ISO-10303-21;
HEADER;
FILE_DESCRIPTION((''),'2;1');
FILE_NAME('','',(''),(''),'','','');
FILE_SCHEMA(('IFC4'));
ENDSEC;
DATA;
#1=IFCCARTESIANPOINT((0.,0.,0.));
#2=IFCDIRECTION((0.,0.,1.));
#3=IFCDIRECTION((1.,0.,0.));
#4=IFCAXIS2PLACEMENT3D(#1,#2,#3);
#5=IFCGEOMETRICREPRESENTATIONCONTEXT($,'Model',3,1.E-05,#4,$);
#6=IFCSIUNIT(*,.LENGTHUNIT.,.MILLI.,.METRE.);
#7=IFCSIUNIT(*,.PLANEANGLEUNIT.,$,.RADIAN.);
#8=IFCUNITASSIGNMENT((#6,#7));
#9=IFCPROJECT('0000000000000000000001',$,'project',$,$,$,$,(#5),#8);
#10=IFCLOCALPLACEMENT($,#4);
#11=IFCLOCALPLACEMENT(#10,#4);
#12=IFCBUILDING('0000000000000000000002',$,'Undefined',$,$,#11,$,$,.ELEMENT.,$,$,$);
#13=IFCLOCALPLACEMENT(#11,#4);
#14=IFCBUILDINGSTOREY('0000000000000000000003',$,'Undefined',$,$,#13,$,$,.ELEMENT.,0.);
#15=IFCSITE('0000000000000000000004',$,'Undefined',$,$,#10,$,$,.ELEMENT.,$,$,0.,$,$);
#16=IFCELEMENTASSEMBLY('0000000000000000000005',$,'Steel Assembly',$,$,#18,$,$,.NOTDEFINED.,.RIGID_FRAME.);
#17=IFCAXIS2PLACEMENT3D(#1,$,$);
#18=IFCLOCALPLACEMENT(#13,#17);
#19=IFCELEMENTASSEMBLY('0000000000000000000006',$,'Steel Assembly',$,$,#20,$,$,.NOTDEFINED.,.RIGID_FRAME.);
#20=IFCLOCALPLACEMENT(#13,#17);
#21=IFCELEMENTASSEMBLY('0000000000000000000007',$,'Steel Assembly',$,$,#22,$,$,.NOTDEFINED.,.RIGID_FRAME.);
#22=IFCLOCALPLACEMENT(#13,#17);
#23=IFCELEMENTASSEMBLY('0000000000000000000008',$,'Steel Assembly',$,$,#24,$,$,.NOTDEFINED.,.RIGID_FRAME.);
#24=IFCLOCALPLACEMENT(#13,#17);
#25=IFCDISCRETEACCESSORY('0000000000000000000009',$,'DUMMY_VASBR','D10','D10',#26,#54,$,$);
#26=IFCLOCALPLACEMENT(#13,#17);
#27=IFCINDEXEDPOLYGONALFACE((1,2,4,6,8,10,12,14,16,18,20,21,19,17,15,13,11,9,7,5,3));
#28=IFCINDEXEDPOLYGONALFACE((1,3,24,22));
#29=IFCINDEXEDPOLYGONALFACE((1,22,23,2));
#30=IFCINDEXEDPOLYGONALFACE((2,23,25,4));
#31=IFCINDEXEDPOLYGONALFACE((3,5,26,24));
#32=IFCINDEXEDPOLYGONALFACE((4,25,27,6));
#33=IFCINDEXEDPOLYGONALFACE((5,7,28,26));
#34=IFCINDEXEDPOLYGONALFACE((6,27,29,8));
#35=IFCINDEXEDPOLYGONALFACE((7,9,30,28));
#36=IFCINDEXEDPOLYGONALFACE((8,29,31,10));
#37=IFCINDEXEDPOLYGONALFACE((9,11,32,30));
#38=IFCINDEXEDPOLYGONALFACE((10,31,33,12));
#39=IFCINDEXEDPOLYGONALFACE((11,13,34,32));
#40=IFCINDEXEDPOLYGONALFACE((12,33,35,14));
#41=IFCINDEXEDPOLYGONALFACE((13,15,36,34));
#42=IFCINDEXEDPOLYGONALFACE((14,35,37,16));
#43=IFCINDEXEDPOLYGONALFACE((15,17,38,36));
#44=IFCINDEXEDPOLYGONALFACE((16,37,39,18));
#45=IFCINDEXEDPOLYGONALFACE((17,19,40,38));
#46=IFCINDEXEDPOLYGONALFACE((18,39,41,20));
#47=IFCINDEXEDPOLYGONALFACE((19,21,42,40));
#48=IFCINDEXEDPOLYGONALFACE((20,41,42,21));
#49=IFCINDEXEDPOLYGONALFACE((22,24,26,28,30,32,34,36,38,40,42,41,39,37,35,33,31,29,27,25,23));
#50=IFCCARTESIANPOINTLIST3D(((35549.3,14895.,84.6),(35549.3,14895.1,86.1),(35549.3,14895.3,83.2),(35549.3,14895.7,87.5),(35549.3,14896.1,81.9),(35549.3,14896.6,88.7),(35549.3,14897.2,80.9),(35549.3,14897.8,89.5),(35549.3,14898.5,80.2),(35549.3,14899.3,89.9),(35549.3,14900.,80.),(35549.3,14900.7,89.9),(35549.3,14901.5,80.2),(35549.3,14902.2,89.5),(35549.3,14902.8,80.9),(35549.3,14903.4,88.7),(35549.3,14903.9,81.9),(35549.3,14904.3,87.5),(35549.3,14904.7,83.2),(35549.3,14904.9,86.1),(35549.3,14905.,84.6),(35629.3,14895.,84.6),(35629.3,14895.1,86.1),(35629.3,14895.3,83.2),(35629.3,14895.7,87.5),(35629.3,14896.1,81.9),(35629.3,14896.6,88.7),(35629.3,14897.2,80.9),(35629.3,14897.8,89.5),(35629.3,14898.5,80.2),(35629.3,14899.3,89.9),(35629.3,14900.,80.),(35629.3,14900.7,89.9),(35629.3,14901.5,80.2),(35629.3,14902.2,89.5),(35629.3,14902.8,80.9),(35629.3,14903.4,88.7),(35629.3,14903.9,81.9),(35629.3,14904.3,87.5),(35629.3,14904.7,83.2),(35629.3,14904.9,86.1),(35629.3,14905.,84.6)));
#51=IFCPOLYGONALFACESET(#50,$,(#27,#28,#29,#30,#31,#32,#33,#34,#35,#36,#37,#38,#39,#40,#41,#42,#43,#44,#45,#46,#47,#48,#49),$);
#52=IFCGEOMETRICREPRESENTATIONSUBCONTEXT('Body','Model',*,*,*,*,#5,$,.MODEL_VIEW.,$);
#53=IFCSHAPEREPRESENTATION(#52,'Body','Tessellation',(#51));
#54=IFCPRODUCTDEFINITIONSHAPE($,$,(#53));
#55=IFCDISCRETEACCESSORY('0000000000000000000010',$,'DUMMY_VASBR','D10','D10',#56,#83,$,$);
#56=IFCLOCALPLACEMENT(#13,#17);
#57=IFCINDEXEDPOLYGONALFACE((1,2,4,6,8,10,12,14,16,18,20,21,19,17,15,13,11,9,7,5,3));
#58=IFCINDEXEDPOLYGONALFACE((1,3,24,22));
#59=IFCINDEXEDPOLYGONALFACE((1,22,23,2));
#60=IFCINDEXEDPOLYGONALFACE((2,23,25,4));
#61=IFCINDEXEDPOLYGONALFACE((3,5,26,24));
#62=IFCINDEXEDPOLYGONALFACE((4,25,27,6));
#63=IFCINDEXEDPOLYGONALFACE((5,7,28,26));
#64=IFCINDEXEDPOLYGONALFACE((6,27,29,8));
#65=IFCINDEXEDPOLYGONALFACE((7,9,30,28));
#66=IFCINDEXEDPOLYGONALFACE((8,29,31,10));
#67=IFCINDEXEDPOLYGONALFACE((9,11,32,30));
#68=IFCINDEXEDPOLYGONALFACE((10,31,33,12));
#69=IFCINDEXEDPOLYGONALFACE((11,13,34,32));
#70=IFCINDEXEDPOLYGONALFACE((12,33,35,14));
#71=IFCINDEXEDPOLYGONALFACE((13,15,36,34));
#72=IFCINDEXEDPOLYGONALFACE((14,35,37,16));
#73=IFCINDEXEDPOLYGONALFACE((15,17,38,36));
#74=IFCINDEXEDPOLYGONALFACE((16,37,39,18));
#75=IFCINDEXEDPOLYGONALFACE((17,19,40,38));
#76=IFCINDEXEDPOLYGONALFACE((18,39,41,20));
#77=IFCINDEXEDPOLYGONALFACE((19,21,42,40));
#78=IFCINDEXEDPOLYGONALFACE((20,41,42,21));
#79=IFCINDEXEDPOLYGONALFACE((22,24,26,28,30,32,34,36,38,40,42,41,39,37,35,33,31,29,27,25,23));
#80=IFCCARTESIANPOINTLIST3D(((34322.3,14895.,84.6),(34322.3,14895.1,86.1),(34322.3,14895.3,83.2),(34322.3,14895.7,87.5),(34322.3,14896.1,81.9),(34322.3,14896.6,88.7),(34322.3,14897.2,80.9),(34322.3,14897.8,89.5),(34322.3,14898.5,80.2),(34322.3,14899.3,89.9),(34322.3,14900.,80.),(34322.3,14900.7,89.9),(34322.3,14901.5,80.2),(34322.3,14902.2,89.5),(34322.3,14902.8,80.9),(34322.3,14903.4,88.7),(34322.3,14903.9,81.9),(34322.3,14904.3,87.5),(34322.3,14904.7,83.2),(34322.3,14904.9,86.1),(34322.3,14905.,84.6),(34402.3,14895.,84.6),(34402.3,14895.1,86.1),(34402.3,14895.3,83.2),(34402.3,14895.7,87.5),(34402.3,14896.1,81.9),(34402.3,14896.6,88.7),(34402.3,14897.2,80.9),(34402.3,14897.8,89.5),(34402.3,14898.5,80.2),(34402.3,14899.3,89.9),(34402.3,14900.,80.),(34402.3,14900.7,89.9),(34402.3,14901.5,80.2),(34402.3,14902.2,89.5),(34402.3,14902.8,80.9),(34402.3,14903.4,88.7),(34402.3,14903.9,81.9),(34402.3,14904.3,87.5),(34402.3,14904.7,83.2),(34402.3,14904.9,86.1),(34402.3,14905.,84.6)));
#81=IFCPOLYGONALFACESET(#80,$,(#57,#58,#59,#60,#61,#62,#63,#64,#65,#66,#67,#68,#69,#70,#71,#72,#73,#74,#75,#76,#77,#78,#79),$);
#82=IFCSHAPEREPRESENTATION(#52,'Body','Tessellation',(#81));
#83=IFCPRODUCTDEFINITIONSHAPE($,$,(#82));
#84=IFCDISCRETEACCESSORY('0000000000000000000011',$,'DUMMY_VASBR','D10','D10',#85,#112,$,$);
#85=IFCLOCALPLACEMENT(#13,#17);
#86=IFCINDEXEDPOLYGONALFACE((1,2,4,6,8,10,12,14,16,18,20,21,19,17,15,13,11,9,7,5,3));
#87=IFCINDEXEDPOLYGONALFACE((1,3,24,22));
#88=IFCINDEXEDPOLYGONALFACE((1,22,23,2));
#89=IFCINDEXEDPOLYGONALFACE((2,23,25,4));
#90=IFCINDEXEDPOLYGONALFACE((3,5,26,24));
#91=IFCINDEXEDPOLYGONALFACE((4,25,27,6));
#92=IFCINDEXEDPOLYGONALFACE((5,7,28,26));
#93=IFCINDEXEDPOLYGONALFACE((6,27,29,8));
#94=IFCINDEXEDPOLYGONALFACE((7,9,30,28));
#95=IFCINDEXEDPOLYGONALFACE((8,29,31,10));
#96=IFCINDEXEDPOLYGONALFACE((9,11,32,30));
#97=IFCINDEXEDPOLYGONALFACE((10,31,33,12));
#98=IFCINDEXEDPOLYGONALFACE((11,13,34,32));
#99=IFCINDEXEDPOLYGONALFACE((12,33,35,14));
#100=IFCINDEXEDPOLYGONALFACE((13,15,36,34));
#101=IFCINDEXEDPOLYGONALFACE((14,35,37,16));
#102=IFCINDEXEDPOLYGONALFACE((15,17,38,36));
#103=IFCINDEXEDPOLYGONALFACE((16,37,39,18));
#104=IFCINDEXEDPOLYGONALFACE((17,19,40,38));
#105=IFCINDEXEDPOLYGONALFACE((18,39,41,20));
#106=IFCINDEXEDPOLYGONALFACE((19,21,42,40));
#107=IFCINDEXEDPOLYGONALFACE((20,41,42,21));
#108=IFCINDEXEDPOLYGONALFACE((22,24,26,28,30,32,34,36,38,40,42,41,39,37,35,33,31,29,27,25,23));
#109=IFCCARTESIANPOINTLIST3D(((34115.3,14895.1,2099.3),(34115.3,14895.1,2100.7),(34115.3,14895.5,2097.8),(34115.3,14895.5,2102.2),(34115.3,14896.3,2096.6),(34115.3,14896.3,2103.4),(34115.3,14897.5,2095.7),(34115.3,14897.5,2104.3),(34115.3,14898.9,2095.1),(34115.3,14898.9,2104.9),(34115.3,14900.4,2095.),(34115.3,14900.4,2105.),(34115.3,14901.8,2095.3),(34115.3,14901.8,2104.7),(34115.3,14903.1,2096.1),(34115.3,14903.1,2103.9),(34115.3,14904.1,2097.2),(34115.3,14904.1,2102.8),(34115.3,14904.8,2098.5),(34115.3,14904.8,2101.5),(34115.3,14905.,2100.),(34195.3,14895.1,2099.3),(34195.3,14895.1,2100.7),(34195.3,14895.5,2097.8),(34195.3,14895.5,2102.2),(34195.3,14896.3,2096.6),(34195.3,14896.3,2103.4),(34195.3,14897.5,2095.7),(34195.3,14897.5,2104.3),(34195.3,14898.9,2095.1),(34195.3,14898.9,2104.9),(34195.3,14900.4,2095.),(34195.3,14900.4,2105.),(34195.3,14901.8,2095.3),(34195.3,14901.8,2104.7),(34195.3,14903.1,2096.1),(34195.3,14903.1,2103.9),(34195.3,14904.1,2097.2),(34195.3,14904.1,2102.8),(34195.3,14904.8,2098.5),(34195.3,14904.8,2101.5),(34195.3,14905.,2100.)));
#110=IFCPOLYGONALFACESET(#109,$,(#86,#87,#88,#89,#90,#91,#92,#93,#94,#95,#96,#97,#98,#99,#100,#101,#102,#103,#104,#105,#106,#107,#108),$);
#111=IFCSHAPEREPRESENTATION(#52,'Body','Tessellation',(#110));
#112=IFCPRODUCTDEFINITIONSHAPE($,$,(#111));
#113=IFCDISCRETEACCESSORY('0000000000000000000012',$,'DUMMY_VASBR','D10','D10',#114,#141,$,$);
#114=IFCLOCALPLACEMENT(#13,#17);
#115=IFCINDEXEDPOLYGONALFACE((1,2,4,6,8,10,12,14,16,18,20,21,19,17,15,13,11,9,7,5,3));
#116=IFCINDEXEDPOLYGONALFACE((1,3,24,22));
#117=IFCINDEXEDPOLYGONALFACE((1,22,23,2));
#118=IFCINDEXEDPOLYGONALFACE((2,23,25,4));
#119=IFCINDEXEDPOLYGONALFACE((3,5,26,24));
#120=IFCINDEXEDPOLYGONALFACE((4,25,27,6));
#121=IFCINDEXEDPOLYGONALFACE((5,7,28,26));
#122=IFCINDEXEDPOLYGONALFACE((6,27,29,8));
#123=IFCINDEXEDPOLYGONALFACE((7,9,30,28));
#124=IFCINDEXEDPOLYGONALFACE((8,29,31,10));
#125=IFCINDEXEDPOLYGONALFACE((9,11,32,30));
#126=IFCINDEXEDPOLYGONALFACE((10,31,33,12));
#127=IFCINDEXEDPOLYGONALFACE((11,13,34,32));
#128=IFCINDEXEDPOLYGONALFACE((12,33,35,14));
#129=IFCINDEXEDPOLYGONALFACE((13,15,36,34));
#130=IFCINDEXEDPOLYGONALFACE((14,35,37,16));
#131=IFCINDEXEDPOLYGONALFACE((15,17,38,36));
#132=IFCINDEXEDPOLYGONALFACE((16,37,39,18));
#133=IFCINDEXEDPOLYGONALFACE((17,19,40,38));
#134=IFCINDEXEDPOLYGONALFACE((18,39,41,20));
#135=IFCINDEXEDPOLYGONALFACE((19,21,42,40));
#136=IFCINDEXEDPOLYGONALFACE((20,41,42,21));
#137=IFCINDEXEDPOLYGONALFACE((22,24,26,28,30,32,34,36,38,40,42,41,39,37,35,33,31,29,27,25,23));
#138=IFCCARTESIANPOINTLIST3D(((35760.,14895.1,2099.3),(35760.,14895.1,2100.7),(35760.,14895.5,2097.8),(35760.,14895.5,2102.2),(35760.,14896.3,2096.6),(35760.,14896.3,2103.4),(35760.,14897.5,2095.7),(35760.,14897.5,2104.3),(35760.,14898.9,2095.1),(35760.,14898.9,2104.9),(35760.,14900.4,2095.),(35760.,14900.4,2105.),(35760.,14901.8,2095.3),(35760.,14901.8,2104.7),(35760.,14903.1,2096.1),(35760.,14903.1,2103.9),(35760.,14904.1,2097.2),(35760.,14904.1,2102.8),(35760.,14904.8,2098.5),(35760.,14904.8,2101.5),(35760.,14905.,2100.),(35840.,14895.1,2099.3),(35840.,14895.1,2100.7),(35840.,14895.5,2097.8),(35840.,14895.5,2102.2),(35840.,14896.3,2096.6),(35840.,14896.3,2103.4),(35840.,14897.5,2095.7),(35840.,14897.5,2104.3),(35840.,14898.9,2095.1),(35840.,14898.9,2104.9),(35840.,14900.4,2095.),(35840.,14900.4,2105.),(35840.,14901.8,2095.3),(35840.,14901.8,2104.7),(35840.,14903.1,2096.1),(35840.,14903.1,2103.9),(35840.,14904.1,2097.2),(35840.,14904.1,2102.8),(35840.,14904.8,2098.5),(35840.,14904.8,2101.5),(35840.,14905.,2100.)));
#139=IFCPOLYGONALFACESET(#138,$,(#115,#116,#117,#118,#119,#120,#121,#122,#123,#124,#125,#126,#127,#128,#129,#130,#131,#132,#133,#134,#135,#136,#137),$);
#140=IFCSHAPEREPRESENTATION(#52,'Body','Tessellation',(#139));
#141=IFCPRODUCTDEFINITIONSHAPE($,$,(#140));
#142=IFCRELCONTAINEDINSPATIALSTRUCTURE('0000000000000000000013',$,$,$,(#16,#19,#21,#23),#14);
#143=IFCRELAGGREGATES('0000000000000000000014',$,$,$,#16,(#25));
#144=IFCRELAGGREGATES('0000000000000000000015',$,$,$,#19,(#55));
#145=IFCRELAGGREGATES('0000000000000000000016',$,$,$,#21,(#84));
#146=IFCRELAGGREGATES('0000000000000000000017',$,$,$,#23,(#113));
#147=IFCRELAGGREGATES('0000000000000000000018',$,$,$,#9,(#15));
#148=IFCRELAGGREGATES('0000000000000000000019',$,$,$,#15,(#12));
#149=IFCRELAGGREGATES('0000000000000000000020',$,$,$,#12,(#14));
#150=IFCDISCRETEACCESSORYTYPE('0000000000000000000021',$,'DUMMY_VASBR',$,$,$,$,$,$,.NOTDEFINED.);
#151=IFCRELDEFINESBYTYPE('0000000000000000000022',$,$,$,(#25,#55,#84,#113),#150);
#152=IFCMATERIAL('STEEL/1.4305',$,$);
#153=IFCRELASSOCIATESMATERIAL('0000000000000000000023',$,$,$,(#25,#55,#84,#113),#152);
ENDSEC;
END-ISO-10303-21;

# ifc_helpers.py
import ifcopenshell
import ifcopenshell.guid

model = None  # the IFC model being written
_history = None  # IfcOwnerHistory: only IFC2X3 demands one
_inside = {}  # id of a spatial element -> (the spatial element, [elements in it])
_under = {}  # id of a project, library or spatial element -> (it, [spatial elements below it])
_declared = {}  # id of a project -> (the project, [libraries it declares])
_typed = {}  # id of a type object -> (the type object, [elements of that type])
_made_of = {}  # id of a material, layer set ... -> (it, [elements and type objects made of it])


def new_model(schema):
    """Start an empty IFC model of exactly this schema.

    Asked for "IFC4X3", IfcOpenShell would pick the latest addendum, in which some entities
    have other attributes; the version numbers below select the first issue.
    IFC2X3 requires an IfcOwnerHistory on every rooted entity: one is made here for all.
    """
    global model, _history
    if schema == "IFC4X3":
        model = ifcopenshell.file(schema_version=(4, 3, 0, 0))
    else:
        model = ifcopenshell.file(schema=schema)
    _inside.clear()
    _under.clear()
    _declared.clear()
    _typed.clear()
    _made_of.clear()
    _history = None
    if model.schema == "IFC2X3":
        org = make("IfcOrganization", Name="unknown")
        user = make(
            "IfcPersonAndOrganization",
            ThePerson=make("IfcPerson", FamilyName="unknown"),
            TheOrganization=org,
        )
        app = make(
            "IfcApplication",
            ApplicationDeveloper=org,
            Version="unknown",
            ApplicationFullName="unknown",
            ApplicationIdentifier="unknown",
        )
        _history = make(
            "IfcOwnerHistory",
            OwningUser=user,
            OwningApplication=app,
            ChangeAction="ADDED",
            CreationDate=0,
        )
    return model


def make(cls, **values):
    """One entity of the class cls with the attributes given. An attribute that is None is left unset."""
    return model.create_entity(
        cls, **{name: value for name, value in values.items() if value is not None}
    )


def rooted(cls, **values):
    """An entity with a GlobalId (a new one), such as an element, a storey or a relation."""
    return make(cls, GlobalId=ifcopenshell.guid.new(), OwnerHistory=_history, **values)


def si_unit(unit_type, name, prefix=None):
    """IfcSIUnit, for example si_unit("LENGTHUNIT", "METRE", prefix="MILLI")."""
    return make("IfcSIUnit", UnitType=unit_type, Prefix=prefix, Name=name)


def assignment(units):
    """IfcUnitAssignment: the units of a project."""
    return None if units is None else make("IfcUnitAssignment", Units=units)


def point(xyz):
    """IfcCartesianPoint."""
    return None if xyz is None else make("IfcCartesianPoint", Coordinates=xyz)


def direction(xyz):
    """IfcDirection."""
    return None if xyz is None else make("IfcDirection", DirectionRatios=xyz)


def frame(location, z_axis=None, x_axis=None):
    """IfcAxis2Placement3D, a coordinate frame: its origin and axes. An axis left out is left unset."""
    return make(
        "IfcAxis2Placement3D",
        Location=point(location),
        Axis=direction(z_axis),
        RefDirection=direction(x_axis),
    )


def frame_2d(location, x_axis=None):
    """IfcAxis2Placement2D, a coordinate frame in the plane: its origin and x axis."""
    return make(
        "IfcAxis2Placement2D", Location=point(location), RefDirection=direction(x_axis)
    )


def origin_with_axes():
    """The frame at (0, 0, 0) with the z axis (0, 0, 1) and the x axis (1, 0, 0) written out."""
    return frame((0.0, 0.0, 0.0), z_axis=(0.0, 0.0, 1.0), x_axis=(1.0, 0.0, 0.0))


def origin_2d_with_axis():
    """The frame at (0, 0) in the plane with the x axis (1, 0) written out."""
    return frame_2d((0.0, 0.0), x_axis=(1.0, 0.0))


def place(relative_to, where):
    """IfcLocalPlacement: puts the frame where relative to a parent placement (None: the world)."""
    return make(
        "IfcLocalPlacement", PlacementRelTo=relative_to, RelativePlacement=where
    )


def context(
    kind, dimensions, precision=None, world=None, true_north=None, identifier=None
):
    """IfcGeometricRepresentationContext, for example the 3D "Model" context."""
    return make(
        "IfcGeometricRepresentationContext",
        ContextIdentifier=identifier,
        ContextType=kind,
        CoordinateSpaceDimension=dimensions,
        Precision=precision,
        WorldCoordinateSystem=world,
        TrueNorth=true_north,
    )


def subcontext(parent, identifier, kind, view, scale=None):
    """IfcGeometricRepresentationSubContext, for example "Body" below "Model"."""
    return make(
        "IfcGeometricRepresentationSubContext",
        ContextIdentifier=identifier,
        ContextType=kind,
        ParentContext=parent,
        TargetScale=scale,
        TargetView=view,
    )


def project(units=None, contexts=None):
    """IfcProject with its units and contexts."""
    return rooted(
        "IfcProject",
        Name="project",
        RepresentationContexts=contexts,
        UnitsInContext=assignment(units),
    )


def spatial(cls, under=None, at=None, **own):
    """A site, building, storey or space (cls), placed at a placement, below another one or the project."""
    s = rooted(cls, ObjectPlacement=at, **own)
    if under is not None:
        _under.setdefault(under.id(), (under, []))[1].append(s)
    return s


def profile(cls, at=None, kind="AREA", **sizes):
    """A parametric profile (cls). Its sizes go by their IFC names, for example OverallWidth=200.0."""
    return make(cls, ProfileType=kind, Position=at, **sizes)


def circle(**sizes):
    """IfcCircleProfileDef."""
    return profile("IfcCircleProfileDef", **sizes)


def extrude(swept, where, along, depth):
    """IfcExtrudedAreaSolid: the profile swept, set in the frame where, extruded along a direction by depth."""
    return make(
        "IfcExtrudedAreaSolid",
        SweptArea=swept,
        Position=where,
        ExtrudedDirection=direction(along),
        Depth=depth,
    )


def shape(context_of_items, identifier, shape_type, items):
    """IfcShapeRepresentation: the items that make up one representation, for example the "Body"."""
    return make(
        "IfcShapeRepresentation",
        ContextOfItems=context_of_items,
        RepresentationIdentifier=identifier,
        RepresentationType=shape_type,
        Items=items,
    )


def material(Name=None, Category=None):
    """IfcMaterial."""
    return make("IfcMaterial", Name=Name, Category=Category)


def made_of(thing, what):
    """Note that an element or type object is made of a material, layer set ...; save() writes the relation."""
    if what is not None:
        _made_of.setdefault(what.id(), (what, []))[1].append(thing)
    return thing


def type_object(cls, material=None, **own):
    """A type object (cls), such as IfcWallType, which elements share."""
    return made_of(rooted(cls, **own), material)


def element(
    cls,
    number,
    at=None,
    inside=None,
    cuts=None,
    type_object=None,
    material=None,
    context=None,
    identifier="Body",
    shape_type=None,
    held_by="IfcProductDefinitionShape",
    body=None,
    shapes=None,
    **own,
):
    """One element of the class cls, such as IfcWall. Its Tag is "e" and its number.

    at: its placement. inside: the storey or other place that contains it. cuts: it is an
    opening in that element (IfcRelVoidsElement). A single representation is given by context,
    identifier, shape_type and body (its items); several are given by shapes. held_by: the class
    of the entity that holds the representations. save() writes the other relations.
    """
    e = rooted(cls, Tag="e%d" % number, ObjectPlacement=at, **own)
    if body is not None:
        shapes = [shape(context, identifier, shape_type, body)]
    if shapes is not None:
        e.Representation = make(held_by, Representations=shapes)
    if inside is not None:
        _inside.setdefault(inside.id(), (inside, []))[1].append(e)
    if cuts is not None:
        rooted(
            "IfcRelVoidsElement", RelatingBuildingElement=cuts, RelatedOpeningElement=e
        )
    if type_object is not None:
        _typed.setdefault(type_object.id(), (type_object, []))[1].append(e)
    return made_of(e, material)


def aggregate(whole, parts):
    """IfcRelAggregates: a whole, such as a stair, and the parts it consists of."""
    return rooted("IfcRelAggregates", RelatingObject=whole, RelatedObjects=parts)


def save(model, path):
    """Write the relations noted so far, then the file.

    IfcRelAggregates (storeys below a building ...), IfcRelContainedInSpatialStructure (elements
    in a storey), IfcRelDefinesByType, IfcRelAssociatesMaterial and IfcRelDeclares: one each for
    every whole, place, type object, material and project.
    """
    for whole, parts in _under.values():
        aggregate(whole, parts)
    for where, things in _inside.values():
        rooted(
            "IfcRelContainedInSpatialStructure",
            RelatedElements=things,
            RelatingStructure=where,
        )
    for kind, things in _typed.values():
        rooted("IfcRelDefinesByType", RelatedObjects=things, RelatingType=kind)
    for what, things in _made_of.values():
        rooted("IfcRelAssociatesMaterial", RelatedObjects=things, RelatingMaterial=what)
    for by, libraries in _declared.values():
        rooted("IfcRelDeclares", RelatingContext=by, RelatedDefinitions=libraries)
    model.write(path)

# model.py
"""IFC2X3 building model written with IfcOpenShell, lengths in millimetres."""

from ifc_helpers import new_model, si_unit, frame, origin_with_axes, origin_2d_with_axis, place, context, subcontext, project, spatial, circle, extrude, material, type_object, element, aggregate, save


model = new_model("IFC2X3")

# Units and contexts
model_context = context("Model", 3, precision=1e-05, world=origin_with_axes())
body_context = subcontext(model_context, "Body", "Model", "MODEL_VIEW")
ifc_project = project(units=[si_unit("LENGTHUNIT", "METRE", prefix="MILLI"), si_unit("PLANEANGLEUNIT", "RADIAN")], contexts=[model_context])

# Site, building, storey
site_placement = place(None, origin_with_axes())
site = spatial("IfcSite", under=ifc_project, at=site_placement, Name="Undefined", CompositionType="ELEMENT", RefElevation=0.0)
building_placement = place(site_placement, origin_with_axes())
building = spatial("IfcBuilding", under=site, at=building_placement, Name="Undefined", CompositionType="ELEMENT")
storey_placement = place(building_placement, origin_with_axes())
storey = spatial("IfcBuildingStorey", under=building, at=storey_placement, Name="Undefined", CompositionType="ELEMENT", Elevation=0.0)

# Element assemblies
assembly_1_placement = place(storey_placement, origin_with_axes())
assembly_1 = element("IfcElementAssembly", 1, at=assembly_1_placement, inside=storey, Name="Steel Assembly", AssemblyPlace="NOTDEFINED", PredefinedType="RIGID_FRAME")
ifc_material_1 = material(Name="STEEL/1.4305")
assembly_2_placement = place(storey_placement, origin_with_axes())
assembly_2 = element("IfcElementAssembly", 2, at=assembly_2_placement, inside=storey, Name="Steel Assembly", AssemblyPlace="NOTDEFINED", PredefinedType="RIGID_FRAME")

# Element assemblies
assembly_3_placement = place(storey_placement, origin_with_axes())
assembly_3 = element("IfcElementAssembly", 3, at=assembly_3_placement, inside=storey, Name="Steel Assembly", AssemblyPlace="NOTDEFINED", PredefinedType="RIGID_FRAME")
assembly_4_placement = place(storey_placement, origin_with_axes())
assembly_4 = element("IfcElementAssembly", 4, at=assembly_4_placement, inside=storey, Name="Steel Assembly", AssemblyPlace="NOTDEFINED", PredefinedType="RIGID_FRAME")

# Discrete accessories
discrete_accessory_type = type_object("IfcDiscreteAccessoryType", Name="DUMMY_VASBR")
discrete_accessory_1_placement = place(assembly_1_placement, frame((35629.3, 14900.0, 85.0), z_axis=(0.0, 1.0, 0.0), x_axis=(-1.0, 0.0, 0.0)))
discrete_accessory_1 = element("IfcDiscreteAccessory", 5, at=discrete_accessory_1_placement, type_object=discrete_accessory_type, material=ifc_material_1, Name="DUMMY_VASBR", Description="D10", ObjectType="D10", context=body_context, shape_type="SweptSolid", body=[
    extrude(circle(Radius=5.0, at=origin_2d_with_axis()), frame((80.0, 0.0, 0.0), z_axis=(-1.0, 0.0, 0.0), x_axis=(0.0, -1.0, 0.0)), (0.0, 0.0, 1.0), 80.0),
])
aggregate(assembly_1, [discrete_accessory_1])
discrete_accessory_2_placement = place(assembly_2_placement, frame((34402.3, 14900.0, 85.0), z_axis=(0.0, 1.0, 0.0), x_axis=(-1.0, 0.0, 0.0)))
discrete_accessory_2 = element("IfcDiscreteAccessory", 6, at=discrete_accessory_2_placement, type_object=discrete_accessory_type, material=ifc_material_1, Name="DUMMY_VASBR", Description="D10", ObjectType="D10", context=body_context, shape_type="SweptSolid", body=[
    extrude(circle(Radius=5.0, at=origin_2d_with_axis()), frame((80.0, 0.0, 0.0), z_axis=(-1.0, 0.0, 0.0), x_axis=(0.0, -1.0, 0.0)), (0.0, 0.0, 1.0), 80.0),
])
aggregate(assembly_2, [discrete_accessory_2])
discrete_accessory_3_placement = place(assembly_3_placement, frame((34195.3, 14900.0, 2100.0), z_axis=(0.0, 0.0, 1.0), x_axis=(-1.0, 0.0, 0.0)))
discrete_accessory_3 = element("IfcDiscreteAccessory", 7, at=discrete_accessory_3_placement, type_object=discrete_accessory_type, material=ifc_material_1, Name="DUMMY_VASBR", Description="D10", ObjectType="D10", context=body_context, shape_type="SweptSolid", body=[
    extrude(circle(Radius=5.0, at=origin_2d_with_axis()), frame((80.0, 0.0, 0.0), z_axis=(-1.0, 0.0, 0.0), x_axis=(0.0, -1.0, 0.0)), (0.0, 0.0, 1.0), 80.0),
])
aggregate(assembly_3, [discrete_accessory_3])
discrete_accessory_4_placement = place(assembly_4_placement, frame((35840.0, 14900.0, 2100.0), z_axis=(0.0, 0.0, 1.0), x_axis=(-1.0, 0.0, 0.0)))
discrete_accessory_4 = element("IfcDiscreteAccessory", 8, at=discrete_accessory_4_placement, type_object=discrete_accessory_type, material=ifc_material_1, Name="DUMMY_VASBR", Description="D10", ObjectType="D10", context=body_context, shape_type="SweptSolid", body=[
    extrude(circle(Radius=5.0, at=origin_2d_with_axis()), frame((80.0, 0.0, 0.0), z_axis=(-1.0, 0.0, 0.0), x_axis=(0.0, -1.0, 0.0)), (0.0, 0.0, 1.0), 80.0),
])
aggregate(assembly_4, [discrete_accessory_4])

save(model, "model.ifc")
